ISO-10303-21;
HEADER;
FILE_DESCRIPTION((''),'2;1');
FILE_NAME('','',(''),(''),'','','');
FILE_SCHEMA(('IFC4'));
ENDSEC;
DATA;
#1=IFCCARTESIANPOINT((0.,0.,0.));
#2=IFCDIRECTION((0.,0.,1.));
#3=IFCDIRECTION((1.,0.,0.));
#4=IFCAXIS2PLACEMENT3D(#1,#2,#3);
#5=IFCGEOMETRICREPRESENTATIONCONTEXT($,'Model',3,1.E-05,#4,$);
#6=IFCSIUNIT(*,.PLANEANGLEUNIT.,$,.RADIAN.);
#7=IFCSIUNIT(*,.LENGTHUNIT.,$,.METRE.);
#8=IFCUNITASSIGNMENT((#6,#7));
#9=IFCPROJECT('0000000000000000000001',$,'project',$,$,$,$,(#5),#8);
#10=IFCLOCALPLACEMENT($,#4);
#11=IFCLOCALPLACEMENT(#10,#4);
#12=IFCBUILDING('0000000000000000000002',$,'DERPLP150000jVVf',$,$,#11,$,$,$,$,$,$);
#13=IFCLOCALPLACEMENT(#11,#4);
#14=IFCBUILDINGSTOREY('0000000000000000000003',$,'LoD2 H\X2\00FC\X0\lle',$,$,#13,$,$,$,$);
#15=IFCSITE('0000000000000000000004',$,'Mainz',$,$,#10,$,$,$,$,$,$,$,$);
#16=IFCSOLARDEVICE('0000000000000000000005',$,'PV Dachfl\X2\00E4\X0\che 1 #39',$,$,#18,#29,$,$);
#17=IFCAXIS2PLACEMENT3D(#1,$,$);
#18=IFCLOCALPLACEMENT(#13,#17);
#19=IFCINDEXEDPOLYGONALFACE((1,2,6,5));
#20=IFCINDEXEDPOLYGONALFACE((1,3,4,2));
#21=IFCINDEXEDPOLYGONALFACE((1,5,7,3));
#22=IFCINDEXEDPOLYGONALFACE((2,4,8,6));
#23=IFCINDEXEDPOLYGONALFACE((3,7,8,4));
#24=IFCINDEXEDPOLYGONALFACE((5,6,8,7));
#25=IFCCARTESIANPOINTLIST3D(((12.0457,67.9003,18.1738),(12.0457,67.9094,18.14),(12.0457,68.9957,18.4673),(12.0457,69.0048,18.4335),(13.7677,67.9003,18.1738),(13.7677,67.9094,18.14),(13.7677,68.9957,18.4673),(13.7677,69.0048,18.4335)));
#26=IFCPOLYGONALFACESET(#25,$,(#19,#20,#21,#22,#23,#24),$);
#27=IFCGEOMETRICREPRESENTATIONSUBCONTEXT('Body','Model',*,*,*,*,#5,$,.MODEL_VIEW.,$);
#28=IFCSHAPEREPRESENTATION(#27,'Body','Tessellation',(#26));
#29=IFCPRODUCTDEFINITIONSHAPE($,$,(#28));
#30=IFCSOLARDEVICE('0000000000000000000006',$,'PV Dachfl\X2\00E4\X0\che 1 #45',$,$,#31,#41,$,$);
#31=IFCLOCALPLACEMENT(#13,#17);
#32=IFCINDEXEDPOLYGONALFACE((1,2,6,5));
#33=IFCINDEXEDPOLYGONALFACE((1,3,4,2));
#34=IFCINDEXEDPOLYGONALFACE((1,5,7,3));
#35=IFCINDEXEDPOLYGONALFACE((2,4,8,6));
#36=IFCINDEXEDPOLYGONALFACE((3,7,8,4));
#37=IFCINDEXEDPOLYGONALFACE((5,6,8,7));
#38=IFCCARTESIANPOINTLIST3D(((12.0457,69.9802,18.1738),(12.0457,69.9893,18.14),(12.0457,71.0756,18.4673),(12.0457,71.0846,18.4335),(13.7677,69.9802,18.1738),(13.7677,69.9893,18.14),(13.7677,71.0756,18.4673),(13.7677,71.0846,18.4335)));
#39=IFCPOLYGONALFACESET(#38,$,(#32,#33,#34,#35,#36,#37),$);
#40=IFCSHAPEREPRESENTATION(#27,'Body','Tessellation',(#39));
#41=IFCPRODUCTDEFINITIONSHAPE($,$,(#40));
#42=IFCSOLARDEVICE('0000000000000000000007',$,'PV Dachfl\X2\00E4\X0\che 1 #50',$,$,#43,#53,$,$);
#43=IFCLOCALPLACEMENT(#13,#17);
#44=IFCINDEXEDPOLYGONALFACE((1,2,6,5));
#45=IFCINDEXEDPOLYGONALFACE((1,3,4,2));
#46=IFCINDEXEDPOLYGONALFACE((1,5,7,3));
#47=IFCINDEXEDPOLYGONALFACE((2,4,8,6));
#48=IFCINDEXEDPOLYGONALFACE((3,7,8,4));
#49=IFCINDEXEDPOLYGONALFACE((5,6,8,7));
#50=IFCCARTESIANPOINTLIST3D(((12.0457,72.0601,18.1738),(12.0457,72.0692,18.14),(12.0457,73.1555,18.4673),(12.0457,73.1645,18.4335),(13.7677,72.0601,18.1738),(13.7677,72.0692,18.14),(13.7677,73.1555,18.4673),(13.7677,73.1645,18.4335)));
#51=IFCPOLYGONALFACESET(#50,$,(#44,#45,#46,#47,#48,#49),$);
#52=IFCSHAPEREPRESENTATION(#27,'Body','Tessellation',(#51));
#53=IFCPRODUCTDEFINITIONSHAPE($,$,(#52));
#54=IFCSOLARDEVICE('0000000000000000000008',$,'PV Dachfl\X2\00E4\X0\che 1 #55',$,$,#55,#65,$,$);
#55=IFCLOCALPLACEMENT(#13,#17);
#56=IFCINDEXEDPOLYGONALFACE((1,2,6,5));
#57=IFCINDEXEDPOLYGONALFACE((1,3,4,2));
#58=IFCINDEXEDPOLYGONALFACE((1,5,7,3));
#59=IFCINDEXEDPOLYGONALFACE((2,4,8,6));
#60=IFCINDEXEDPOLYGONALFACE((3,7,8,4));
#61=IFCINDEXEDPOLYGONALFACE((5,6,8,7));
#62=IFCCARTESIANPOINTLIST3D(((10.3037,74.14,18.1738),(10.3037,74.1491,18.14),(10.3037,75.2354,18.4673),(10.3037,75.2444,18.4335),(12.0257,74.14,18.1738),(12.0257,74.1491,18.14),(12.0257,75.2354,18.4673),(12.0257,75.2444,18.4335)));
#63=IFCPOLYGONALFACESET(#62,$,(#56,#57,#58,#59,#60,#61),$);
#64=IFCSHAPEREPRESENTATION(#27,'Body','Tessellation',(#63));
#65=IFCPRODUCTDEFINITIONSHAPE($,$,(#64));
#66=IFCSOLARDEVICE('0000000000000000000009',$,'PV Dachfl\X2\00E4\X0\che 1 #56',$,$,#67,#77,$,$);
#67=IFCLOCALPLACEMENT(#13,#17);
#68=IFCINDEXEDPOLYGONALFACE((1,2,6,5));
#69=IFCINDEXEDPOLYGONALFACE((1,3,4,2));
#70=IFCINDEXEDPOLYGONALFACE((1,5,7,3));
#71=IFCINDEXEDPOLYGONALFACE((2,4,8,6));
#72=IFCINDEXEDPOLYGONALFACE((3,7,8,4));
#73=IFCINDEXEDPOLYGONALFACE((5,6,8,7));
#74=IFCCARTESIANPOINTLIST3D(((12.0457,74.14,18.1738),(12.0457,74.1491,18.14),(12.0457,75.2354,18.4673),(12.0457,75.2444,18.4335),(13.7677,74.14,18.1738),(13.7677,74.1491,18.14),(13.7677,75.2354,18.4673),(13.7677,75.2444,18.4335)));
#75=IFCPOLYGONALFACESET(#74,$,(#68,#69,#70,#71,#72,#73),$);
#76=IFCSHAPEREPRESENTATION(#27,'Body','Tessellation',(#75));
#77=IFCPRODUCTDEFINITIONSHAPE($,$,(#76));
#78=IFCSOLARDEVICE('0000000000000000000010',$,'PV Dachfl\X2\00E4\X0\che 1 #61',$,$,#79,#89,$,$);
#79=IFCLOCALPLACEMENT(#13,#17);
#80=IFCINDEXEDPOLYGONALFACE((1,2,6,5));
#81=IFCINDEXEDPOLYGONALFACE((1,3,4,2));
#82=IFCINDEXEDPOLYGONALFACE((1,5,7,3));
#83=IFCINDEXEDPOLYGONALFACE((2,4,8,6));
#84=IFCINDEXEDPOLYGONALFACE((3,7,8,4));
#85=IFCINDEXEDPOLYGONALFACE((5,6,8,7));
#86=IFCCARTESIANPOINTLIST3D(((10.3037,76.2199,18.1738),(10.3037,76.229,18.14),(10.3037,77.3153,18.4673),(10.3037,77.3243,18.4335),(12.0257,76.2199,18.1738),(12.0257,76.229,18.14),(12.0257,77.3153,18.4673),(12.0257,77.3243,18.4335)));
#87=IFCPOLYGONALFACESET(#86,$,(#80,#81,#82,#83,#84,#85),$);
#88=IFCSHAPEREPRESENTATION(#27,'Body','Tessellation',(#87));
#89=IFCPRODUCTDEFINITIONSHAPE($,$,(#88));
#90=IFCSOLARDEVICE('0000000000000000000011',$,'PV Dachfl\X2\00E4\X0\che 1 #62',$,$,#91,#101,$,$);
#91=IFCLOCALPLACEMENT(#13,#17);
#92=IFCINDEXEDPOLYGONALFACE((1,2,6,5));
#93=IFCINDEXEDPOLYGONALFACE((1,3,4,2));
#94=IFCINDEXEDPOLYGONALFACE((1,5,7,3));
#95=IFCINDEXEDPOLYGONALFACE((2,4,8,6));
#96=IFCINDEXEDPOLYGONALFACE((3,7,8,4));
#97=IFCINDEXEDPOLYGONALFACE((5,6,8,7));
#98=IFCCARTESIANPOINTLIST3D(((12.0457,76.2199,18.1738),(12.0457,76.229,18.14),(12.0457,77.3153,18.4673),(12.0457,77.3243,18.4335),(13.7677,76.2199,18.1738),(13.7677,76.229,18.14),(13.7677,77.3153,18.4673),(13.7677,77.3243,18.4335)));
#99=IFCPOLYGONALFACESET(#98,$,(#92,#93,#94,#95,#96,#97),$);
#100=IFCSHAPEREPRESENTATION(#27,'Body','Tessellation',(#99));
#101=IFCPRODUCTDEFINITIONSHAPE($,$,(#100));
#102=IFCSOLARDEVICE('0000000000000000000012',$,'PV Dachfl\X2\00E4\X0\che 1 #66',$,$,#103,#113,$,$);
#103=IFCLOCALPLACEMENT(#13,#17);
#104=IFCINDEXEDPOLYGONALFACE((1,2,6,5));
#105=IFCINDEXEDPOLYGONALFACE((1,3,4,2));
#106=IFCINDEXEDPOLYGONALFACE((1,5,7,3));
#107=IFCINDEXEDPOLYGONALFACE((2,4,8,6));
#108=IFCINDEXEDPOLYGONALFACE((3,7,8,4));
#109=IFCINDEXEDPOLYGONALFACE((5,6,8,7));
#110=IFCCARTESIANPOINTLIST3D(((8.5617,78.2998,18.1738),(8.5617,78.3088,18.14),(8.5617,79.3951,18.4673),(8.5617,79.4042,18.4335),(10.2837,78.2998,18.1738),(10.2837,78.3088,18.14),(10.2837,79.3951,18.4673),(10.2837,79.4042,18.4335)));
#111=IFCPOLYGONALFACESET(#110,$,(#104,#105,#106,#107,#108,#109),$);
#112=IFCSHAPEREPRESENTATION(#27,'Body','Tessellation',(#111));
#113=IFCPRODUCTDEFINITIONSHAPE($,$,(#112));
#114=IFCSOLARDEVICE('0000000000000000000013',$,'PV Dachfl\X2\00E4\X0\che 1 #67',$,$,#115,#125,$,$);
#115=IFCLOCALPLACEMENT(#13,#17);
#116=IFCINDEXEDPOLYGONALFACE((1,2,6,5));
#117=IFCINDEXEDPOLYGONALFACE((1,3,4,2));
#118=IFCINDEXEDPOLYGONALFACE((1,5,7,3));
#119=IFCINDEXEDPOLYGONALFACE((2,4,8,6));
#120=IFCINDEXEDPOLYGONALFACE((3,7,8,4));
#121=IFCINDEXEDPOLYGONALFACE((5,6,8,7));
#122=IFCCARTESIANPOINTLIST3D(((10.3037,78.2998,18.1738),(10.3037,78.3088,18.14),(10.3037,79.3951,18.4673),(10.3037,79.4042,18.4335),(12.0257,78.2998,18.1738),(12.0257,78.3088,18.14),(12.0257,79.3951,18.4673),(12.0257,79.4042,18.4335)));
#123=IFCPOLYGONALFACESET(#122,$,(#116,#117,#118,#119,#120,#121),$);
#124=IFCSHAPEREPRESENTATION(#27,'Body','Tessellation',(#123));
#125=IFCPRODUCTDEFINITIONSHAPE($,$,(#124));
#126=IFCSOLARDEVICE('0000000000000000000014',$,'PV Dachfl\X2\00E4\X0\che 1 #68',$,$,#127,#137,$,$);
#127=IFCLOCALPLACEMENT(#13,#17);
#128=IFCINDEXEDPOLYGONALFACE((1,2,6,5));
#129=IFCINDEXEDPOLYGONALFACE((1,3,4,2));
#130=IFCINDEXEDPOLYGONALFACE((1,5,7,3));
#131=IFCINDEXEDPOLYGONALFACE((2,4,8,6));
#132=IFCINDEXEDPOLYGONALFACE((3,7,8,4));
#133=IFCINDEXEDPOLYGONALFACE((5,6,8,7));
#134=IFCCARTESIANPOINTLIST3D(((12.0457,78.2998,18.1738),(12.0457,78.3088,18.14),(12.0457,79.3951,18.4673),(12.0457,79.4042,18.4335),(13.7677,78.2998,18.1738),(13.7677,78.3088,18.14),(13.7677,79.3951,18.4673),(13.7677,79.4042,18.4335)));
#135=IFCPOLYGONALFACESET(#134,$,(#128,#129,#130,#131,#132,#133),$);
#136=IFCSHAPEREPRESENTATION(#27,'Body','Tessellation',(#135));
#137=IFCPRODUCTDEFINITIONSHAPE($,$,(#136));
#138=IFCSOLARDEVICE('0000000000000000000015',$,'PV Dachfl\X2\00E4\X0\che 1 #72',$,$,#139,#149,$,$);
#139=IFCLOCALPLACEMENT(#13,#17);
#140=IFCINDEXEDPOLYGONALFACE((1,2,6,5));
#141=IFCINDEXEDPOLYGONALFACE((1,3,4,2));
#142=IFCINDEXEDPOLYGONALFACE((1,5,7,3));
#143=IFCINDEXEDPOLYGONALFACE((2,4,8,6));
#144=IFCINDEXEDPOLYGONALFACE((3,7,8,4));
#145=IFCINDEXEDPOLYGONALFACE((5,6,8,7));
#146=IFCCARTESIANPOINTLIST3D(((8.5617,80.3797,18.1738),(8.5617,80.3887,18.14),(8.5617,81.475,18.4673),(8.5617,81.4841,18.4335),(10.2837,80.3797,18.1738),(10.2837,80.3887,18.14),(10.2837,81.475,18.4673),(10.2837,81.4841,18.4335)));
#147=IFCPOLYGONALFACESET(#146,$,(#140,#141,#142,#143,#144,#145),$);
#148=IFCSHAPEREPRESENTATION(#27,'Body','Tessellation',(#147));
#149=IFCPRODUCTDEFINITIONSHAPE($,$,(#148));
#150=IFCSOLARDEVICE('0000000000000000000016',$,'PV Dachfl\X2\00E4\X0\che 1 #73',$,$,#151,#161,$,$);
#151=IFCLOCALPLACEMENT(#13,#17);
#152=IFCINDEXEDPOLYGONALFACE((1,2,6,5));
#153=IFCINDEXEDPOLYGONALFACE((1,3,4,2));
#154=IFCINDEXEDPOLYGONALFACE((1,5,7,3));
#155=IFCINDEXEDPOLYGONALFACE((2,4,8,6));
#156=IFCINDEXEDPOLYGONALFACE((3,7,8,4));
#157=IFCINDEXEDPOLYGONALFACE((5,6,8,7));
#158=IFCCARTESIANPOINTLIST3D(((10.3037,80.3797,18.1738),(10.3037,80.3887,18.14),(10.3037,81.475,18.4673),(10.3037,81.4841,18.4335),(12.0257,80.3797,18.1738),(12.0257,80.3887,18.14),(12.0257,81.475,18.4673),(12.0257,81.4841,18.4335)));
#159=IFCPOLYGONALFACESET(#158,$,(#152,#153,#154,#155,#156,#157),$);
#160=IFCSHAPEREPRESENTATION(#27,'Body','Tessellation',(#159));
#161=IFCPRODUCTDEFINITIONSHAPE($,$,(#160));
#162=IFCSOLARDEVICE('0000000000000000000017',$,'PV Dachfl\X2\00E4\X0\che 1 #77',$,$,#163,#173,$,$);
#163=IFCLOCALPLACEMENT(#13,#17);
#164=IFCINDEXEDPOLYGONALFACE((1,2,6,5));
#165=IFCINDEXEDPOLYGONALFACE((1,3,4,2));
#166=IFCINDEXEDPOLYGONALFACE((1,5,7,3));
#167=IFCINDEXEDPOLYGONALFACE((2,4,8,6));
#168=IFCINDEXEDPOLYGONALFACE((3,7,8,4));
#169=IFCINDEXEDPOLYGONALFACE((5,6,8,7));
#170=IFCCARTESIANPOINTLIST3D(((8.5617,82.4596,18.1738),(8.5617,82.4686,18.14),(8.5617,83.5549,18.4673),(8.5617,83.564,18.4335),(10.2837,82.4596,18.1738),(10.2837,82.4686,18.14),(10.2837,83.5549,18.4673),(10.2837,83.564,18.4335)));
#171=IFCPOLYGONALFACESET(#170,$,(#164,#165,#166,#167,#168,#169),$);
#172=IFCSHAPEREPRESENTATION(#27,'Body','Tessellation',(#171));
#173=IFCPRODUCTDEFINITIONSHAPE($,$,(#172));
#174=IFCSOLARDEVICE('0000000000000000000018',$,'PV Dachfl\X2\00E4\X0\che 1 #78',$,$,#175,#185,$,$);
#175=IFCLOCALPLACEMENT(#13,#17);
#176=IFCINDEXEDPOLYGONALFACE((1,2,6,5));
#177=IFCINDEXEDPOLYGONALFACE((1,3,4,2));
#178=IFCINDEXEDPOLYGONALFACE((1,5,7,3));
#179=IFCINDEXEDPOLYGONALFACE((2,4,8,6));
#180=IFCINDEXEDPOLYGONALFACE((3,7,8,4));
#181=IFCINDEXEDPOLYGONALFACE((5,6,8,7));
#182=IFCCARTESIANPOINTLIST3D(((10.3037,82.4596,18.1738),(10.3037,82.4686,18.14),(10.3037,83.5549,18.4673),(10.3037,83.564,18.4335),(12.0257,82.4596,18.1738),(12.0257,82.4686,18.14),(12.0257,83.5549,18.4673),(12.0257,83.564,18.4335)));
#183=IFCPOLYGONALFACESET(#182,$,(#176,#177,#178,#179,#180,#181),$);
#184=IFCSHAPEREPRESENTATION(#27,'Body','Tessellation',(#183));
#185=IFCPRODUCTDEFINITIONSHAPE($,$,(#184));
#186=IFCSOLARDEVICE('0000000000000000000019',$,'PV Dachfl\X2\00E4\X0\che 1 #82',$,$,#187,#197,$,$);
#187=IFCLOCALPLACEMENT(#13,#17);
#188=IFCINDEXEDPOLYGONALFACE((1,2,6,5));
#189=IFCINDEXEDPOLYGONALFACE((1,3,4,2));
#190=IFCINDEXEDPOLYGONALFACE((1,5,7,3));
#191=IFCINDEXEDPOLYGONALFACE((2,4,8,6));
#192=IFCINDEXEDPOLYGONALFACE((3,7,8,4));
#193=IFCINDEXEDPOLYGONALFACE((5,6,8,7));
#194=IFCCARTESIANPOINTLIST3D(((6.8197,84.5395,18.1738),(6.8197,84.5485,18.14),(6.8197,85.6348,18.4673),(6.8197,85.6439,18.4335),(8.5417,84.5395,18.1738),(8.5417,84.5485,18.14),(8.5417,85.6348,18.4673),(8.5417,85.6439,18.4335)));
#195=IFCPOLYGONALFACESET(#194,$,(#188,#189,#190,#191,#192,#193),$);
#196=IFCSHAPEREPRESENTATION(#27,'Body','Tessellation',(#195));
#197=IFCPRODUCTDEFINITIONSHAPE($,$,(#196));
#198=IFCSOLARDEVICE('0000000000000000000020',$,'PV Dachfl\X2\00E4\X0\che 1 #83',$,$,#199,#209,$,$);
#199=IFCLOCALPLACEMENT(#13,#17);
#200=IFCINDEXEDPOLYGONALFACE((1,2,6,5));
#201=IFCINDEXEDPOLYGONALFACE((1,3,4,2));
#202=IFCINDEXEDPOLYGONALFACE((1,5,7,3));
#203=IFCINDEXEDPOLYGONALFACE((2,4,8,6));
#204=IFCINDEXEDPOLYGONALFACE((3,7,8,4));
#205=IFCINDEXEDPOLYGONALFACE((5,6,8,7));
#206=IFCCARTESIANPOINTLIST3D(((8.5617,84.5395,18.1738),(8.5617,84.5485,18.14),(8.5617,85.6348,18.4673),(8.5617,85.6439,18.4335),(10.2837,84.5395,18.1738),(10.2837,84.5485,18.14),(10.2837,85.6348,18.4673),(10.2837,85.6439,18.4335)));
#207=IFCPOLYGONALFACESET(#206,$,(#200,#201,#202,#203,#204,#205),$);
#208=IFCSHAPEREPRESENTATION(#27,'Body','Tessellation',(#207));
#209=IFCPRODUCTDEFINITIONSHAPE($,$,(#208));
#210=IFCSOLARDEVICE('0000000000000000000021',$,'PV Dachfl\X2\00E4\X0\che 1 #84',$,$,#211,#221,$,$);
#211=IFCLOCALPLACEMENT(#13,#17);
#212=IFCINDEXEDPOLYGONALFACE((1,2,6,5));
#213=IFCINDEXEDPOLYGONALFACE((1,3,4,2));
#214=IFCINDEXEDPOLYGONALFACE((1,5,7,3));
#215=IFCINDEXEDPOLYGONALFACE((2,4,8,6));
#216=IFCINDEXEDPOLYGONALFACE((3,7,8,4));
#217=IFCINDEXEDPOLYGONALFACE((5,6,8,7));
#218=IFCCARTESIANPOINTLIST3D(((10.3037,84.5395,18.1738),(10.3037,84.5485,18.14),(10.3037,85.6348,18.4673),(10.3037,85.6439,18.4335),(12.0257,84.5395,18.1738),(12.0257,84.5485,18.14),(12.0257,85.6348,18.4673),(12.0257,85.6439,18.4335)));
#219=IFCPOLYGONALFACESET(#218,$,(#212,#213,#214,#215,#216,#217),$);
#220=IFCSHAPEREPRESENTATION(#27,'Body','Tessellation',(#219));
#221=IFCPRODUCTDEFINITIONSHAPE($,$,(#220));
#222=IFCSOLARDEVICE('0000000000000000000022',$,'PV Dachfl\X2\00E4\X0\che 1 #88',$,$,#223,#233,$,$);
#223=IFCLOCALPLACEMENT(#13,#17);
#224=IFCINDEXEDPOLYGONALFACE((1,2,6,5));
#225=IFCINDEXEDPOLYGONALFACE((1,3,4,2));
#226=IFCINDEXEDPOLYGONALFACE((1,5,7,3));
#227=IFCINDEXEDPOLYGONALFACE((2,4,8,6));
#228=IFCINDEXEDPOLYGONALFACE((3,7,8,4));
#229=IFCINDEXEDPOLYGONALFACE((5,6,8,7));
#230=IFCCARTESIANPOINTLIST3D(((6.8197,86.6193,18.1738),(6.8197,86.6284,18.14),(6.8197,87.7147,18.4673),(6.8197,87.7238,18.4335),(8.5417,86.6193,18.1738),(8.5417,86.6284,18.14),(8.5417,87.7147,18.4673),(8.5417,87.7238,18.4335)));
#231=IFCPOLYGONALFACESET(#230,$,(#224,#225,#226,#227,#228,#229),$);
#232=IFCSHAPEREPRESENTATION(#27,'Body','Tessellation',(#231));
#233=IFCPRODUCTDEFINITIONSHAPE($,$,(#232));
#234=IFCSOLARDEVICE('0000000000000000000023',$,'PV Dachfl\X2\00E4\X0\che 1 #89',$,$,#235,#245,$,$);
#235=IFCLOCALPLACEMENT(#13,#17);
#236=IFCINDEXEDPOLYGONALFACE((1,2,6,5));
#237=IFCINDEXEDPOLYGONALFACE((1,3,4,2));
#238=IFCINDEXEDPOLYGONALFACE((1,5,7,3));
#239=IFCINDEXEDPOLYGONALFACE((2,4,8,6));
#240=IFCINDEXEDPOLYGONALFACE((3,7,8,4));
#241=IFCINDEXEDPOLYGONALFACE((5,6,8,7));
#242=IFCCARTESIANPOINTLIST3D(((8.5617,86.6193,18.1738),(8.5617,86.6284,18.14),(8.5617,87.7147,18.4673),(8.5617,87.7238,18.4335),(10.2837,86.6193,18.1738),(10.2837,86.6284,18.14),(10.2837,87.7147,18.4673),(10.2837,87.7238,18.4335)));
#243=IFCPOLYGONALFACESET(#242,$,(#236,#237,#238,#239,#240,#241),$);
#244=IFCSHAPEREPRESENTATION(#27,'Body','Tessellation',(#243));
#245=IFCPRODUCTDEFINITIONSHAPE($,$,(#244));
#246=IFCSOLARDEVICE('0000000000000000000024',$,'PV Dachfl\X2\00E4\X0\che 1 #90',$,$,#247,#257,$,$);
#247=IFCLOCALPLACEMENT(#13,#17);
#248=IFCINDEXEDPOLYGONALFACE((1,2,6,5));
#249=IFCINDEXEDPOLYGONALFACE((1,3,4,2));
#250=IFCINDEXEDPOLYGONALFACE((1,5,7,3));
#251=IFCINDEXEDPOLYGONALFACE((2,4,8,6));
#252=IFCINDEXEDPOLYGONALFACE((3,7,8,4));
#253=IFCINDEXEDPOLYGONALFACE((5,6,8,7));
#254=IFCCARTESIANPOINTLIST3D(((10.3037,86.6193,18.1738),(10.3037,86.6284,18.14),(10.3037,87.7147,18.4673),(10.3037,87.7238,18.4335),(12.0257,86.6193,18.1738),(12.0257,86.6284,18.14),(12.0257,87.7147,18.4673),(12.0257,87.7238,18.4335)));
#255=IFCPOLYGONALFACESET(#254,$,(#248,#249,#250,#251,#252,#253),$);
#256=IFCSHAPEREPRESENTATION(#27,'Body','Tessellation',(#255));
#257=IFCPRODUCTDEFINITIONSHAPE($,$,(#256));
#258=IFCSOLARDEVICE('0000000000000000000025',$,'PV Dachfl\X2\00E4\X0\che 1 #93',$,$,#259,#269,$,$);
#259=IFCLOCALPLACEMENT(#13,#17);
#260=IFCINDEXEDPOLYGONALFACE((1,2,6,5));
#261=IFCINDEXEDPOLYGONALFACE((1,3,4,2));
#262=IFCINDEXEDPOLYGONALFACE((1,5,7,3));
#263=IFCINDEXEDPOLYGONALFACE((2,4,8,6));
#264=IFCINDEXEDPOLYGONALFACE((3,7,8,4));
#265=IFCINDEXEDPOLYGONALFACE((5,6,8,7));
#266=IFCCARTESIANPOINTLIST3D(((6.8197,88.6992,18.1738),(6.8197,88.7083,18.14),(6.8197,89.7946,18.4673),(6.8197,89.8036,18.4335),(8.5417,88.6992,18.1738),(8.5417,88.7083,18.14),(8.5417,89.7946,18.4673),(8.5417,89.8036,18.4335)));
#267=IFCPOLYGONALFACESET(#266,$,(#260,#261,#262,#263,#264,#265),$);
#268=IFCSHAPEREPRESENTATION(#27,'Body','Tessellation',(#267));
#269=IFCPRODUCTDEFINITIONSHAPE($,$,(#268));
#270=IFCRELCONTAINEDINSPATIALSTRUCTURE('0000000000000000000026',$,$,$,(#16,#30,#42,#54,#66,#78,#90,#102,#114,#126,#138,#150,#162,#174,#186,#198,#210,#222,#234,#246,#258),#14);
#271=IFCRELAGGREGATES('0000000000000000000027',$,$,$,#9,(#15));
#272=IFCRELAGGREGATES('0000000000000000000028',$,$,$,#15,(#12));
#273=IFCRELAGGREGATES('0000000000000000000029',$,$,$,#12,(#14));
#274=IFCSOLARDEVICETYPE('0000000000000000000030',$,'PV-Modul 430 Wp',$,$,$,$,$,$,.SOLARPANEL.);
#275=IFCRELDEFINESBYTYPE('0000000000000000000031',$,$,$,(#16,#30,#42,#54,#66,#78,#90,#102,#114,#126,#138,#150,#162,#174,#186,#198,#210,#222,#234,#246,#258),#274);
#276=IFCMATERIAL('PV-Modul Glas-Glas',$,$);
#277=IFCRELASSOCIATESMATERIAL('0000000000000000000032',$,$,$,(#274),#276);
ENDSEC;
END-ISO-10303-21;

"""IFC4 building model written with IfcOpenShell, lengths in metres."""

from ifc_helpers import new_model, si_unit, frame, frame_2d, origin, origin_with_axes, place, context, subcontext, project, spatial, rectangle, extrude, source, transform, mapped, material, type_object, type_shapes, element, save


model = new_model("IFC4")

# Units and contexts
model_context = context("Model", 3, precision=1e-05, world=origin_with_axes())
body_context = subcontext(model_context, "Body", "Model", "MODEL_VIEW")
ifc_project = project(units=[si_unit("PLANEANGLEUNIT", "RADIAN"), si_unit("LENGTHUNIT", "METRE")], contexts=[model_context])

# Site, building, storey
site_placement = place(None, origin_with_axes())
site = spatial("IfcSite", under=ifc_project, at=site_placement, Name="Mainz")
building_placement = place(site_placement, origin_with_axes())
building = spatial("IfcBuilding", under=site, at=building_placement, Name="DERPLP150000jVVf")
storey_placement = place(building_placement, origin_with_axes())
storey = spatial("IfcBuildingStorey", under=building, at=storey_placement, Name="LoD2 Hülle")

# Solar devices
ifc_material = material(Name="PV-Modul Glas-Glas")
solar_device_type = type_object("IfcSolarDeviceType", Name="PV-Modul 430 Wp", PredefinedType="SOLARPANEL", material=ifc_material)
shared_shape = source(origin_with_axes(), body_context, "Body", "SweptSolid", [
    extrude(rectangle(XDim=1.722, YDim=1.134, at=frame_2d((0.861, 0.567))), origin(), (0.0, 0.0, 1.0), 0.035),
])
type_shapes(solar_device_type, [shared_shape])
for number, where, z_axis, x_axis, name in (
    (1, (12.0457, 67.9094, 18.14), (0.0, -0.258819, 0.965926), (1.0, 0.0, 0.0), "PV Dachfläche 1 #39"),
    (2, (12.0457, 69.9893, 18.14), (0.0, -0.258819, 0.965926), (1.0, 0.0, 0.0), "PV Dachfläche 1 #45"),
    (3, (12.0457, 72.0692, 18.14), (0.0, -0.258819, 0.965926), (1.0, 0.0, 0.0), "PV Dachfläche 1 #50"),
    (4, (10.3037, 74.1491, 18.14), (0.0, -0.258819, 0.965926), (1.0, 0.0, 0.0), "PV Dachfläche 1 #55"),
    (5, (12.0457, 74.1491, 18.14), (0.0, -0.258819, 0.965926), (1.0, 0.0, 0.0), "PV Dachfläche 1 #56"),
    (6, (10.3037, 76.229, 18.14), (0.0, -0.258819, 0.965926), (1.0, 0.0, 0.0), "PV Dachfläche 1 #61"),
    (7, (12.0457, 76.229, 18.14), (0.0, -0.258819, 0.965926), (1.0, 0.0, 0.0), "PV Dachfläche 1 #62"),
    (8, (8.5617, 78.3088, 18.14), (0.0, -0.258819, 0.965926), (1.0, 0.0, 0.0), "PV Dachfläche 1 #66"),
    (9, (10.3037, 78.3088, 18.14), (0.0, -0.258819, 0.965926), (1.0, 0.0, 0.0), "PV Dachfläche 1 #67"),
    (10, (12.0457, 78.3088, 18.14), (0.0, -0.258819, 0.965926), (1.0, 0.0, 0.0), "PV Dachfläche 1 #68"),
    (11, (8.5617, 80.3887, 18.14), (0.0, -0.258819, 0.965926), (1.0, 0.0, 0.0), "PV Dachfläche 1 #72"),
    (12, (10.3037, 80.3887, 18.14), (0.0, -0.258819, 0.965926), (1.0, 0.0, 0.0), "PV Dachfläche 1 #73"),
    (13, (8.5617, 82.4686, 18.14), (0.0, -0.258819, 0.965926), (1.0, 0.0, 0.0), "PV Dachfläche 1 #77"),
    (14, (10.3037, 82.4686, 18.14), (0.0, -0.258819, 0.965926), (1.0, 0.0, 0.0), "PV Dachfläche 1 #78"),
    (15, (6.8197, 84.5485, 18.14), (0.0, -0.258819, 0.965926), (1.0, 0.0, 0.0), "PV Dachfläche 1 #82"),
    (16, (8.5617, 84.5485, 18.14), (0.0, -0.258819, 0.965926), (1.0, 0.0, 0.0), "PV Dachfläche 1 #83"),
    (17, (10.3037, 84.5485, 18.14), (0.0, -0.258819, 0.965926), (1.0, 0.0, 0.0), "PV Dachfläche 1 #84"),
    (18, (6.8197, 86.6284, 18.14), (0.0, -0.258819, 0.965926), (1.0, 0.0, 0.0), "PV Dachfläche 1 #88"),
    (19, (8.5617, 86.6284, 18.14), (0.0, -0.258819, 0.965926), (1.0, 0.0, 0.0), "PV Dachfläche 1 #89"),
    (20, (10.3037, 86.6284, 18.14), (0.0, -0.258819, 0.965926), (1.0, 0.0, 0.0), "PV Dachfläche 1 #90"),
    (21, (6.8197, 88.7083, 18.14), (0.0, -0.258819, 0.965926), (1.0, 0.0, 0.0), "PV Dachfläche 1 #93"),
):
    element("IfcSolarDevice", number, at=place(storey_placement, frame(where, z_axis=z_axis, x_axis=x_axis)), inside=storey, type_object=solar_device_type, Name=name, context=body_context, shape_type="MappedRepresentation", body=[
        mapped(shared_shape, transform((0.0, 0.0, 0.0), x_axis=(1.0, 0.0, 0.0), y_axis=(0.0, 1.0, 0.0), z_axis=(0.0, 0.0, 1.0), scale=1.0)),
    ])

save(model, "model.ifc")
